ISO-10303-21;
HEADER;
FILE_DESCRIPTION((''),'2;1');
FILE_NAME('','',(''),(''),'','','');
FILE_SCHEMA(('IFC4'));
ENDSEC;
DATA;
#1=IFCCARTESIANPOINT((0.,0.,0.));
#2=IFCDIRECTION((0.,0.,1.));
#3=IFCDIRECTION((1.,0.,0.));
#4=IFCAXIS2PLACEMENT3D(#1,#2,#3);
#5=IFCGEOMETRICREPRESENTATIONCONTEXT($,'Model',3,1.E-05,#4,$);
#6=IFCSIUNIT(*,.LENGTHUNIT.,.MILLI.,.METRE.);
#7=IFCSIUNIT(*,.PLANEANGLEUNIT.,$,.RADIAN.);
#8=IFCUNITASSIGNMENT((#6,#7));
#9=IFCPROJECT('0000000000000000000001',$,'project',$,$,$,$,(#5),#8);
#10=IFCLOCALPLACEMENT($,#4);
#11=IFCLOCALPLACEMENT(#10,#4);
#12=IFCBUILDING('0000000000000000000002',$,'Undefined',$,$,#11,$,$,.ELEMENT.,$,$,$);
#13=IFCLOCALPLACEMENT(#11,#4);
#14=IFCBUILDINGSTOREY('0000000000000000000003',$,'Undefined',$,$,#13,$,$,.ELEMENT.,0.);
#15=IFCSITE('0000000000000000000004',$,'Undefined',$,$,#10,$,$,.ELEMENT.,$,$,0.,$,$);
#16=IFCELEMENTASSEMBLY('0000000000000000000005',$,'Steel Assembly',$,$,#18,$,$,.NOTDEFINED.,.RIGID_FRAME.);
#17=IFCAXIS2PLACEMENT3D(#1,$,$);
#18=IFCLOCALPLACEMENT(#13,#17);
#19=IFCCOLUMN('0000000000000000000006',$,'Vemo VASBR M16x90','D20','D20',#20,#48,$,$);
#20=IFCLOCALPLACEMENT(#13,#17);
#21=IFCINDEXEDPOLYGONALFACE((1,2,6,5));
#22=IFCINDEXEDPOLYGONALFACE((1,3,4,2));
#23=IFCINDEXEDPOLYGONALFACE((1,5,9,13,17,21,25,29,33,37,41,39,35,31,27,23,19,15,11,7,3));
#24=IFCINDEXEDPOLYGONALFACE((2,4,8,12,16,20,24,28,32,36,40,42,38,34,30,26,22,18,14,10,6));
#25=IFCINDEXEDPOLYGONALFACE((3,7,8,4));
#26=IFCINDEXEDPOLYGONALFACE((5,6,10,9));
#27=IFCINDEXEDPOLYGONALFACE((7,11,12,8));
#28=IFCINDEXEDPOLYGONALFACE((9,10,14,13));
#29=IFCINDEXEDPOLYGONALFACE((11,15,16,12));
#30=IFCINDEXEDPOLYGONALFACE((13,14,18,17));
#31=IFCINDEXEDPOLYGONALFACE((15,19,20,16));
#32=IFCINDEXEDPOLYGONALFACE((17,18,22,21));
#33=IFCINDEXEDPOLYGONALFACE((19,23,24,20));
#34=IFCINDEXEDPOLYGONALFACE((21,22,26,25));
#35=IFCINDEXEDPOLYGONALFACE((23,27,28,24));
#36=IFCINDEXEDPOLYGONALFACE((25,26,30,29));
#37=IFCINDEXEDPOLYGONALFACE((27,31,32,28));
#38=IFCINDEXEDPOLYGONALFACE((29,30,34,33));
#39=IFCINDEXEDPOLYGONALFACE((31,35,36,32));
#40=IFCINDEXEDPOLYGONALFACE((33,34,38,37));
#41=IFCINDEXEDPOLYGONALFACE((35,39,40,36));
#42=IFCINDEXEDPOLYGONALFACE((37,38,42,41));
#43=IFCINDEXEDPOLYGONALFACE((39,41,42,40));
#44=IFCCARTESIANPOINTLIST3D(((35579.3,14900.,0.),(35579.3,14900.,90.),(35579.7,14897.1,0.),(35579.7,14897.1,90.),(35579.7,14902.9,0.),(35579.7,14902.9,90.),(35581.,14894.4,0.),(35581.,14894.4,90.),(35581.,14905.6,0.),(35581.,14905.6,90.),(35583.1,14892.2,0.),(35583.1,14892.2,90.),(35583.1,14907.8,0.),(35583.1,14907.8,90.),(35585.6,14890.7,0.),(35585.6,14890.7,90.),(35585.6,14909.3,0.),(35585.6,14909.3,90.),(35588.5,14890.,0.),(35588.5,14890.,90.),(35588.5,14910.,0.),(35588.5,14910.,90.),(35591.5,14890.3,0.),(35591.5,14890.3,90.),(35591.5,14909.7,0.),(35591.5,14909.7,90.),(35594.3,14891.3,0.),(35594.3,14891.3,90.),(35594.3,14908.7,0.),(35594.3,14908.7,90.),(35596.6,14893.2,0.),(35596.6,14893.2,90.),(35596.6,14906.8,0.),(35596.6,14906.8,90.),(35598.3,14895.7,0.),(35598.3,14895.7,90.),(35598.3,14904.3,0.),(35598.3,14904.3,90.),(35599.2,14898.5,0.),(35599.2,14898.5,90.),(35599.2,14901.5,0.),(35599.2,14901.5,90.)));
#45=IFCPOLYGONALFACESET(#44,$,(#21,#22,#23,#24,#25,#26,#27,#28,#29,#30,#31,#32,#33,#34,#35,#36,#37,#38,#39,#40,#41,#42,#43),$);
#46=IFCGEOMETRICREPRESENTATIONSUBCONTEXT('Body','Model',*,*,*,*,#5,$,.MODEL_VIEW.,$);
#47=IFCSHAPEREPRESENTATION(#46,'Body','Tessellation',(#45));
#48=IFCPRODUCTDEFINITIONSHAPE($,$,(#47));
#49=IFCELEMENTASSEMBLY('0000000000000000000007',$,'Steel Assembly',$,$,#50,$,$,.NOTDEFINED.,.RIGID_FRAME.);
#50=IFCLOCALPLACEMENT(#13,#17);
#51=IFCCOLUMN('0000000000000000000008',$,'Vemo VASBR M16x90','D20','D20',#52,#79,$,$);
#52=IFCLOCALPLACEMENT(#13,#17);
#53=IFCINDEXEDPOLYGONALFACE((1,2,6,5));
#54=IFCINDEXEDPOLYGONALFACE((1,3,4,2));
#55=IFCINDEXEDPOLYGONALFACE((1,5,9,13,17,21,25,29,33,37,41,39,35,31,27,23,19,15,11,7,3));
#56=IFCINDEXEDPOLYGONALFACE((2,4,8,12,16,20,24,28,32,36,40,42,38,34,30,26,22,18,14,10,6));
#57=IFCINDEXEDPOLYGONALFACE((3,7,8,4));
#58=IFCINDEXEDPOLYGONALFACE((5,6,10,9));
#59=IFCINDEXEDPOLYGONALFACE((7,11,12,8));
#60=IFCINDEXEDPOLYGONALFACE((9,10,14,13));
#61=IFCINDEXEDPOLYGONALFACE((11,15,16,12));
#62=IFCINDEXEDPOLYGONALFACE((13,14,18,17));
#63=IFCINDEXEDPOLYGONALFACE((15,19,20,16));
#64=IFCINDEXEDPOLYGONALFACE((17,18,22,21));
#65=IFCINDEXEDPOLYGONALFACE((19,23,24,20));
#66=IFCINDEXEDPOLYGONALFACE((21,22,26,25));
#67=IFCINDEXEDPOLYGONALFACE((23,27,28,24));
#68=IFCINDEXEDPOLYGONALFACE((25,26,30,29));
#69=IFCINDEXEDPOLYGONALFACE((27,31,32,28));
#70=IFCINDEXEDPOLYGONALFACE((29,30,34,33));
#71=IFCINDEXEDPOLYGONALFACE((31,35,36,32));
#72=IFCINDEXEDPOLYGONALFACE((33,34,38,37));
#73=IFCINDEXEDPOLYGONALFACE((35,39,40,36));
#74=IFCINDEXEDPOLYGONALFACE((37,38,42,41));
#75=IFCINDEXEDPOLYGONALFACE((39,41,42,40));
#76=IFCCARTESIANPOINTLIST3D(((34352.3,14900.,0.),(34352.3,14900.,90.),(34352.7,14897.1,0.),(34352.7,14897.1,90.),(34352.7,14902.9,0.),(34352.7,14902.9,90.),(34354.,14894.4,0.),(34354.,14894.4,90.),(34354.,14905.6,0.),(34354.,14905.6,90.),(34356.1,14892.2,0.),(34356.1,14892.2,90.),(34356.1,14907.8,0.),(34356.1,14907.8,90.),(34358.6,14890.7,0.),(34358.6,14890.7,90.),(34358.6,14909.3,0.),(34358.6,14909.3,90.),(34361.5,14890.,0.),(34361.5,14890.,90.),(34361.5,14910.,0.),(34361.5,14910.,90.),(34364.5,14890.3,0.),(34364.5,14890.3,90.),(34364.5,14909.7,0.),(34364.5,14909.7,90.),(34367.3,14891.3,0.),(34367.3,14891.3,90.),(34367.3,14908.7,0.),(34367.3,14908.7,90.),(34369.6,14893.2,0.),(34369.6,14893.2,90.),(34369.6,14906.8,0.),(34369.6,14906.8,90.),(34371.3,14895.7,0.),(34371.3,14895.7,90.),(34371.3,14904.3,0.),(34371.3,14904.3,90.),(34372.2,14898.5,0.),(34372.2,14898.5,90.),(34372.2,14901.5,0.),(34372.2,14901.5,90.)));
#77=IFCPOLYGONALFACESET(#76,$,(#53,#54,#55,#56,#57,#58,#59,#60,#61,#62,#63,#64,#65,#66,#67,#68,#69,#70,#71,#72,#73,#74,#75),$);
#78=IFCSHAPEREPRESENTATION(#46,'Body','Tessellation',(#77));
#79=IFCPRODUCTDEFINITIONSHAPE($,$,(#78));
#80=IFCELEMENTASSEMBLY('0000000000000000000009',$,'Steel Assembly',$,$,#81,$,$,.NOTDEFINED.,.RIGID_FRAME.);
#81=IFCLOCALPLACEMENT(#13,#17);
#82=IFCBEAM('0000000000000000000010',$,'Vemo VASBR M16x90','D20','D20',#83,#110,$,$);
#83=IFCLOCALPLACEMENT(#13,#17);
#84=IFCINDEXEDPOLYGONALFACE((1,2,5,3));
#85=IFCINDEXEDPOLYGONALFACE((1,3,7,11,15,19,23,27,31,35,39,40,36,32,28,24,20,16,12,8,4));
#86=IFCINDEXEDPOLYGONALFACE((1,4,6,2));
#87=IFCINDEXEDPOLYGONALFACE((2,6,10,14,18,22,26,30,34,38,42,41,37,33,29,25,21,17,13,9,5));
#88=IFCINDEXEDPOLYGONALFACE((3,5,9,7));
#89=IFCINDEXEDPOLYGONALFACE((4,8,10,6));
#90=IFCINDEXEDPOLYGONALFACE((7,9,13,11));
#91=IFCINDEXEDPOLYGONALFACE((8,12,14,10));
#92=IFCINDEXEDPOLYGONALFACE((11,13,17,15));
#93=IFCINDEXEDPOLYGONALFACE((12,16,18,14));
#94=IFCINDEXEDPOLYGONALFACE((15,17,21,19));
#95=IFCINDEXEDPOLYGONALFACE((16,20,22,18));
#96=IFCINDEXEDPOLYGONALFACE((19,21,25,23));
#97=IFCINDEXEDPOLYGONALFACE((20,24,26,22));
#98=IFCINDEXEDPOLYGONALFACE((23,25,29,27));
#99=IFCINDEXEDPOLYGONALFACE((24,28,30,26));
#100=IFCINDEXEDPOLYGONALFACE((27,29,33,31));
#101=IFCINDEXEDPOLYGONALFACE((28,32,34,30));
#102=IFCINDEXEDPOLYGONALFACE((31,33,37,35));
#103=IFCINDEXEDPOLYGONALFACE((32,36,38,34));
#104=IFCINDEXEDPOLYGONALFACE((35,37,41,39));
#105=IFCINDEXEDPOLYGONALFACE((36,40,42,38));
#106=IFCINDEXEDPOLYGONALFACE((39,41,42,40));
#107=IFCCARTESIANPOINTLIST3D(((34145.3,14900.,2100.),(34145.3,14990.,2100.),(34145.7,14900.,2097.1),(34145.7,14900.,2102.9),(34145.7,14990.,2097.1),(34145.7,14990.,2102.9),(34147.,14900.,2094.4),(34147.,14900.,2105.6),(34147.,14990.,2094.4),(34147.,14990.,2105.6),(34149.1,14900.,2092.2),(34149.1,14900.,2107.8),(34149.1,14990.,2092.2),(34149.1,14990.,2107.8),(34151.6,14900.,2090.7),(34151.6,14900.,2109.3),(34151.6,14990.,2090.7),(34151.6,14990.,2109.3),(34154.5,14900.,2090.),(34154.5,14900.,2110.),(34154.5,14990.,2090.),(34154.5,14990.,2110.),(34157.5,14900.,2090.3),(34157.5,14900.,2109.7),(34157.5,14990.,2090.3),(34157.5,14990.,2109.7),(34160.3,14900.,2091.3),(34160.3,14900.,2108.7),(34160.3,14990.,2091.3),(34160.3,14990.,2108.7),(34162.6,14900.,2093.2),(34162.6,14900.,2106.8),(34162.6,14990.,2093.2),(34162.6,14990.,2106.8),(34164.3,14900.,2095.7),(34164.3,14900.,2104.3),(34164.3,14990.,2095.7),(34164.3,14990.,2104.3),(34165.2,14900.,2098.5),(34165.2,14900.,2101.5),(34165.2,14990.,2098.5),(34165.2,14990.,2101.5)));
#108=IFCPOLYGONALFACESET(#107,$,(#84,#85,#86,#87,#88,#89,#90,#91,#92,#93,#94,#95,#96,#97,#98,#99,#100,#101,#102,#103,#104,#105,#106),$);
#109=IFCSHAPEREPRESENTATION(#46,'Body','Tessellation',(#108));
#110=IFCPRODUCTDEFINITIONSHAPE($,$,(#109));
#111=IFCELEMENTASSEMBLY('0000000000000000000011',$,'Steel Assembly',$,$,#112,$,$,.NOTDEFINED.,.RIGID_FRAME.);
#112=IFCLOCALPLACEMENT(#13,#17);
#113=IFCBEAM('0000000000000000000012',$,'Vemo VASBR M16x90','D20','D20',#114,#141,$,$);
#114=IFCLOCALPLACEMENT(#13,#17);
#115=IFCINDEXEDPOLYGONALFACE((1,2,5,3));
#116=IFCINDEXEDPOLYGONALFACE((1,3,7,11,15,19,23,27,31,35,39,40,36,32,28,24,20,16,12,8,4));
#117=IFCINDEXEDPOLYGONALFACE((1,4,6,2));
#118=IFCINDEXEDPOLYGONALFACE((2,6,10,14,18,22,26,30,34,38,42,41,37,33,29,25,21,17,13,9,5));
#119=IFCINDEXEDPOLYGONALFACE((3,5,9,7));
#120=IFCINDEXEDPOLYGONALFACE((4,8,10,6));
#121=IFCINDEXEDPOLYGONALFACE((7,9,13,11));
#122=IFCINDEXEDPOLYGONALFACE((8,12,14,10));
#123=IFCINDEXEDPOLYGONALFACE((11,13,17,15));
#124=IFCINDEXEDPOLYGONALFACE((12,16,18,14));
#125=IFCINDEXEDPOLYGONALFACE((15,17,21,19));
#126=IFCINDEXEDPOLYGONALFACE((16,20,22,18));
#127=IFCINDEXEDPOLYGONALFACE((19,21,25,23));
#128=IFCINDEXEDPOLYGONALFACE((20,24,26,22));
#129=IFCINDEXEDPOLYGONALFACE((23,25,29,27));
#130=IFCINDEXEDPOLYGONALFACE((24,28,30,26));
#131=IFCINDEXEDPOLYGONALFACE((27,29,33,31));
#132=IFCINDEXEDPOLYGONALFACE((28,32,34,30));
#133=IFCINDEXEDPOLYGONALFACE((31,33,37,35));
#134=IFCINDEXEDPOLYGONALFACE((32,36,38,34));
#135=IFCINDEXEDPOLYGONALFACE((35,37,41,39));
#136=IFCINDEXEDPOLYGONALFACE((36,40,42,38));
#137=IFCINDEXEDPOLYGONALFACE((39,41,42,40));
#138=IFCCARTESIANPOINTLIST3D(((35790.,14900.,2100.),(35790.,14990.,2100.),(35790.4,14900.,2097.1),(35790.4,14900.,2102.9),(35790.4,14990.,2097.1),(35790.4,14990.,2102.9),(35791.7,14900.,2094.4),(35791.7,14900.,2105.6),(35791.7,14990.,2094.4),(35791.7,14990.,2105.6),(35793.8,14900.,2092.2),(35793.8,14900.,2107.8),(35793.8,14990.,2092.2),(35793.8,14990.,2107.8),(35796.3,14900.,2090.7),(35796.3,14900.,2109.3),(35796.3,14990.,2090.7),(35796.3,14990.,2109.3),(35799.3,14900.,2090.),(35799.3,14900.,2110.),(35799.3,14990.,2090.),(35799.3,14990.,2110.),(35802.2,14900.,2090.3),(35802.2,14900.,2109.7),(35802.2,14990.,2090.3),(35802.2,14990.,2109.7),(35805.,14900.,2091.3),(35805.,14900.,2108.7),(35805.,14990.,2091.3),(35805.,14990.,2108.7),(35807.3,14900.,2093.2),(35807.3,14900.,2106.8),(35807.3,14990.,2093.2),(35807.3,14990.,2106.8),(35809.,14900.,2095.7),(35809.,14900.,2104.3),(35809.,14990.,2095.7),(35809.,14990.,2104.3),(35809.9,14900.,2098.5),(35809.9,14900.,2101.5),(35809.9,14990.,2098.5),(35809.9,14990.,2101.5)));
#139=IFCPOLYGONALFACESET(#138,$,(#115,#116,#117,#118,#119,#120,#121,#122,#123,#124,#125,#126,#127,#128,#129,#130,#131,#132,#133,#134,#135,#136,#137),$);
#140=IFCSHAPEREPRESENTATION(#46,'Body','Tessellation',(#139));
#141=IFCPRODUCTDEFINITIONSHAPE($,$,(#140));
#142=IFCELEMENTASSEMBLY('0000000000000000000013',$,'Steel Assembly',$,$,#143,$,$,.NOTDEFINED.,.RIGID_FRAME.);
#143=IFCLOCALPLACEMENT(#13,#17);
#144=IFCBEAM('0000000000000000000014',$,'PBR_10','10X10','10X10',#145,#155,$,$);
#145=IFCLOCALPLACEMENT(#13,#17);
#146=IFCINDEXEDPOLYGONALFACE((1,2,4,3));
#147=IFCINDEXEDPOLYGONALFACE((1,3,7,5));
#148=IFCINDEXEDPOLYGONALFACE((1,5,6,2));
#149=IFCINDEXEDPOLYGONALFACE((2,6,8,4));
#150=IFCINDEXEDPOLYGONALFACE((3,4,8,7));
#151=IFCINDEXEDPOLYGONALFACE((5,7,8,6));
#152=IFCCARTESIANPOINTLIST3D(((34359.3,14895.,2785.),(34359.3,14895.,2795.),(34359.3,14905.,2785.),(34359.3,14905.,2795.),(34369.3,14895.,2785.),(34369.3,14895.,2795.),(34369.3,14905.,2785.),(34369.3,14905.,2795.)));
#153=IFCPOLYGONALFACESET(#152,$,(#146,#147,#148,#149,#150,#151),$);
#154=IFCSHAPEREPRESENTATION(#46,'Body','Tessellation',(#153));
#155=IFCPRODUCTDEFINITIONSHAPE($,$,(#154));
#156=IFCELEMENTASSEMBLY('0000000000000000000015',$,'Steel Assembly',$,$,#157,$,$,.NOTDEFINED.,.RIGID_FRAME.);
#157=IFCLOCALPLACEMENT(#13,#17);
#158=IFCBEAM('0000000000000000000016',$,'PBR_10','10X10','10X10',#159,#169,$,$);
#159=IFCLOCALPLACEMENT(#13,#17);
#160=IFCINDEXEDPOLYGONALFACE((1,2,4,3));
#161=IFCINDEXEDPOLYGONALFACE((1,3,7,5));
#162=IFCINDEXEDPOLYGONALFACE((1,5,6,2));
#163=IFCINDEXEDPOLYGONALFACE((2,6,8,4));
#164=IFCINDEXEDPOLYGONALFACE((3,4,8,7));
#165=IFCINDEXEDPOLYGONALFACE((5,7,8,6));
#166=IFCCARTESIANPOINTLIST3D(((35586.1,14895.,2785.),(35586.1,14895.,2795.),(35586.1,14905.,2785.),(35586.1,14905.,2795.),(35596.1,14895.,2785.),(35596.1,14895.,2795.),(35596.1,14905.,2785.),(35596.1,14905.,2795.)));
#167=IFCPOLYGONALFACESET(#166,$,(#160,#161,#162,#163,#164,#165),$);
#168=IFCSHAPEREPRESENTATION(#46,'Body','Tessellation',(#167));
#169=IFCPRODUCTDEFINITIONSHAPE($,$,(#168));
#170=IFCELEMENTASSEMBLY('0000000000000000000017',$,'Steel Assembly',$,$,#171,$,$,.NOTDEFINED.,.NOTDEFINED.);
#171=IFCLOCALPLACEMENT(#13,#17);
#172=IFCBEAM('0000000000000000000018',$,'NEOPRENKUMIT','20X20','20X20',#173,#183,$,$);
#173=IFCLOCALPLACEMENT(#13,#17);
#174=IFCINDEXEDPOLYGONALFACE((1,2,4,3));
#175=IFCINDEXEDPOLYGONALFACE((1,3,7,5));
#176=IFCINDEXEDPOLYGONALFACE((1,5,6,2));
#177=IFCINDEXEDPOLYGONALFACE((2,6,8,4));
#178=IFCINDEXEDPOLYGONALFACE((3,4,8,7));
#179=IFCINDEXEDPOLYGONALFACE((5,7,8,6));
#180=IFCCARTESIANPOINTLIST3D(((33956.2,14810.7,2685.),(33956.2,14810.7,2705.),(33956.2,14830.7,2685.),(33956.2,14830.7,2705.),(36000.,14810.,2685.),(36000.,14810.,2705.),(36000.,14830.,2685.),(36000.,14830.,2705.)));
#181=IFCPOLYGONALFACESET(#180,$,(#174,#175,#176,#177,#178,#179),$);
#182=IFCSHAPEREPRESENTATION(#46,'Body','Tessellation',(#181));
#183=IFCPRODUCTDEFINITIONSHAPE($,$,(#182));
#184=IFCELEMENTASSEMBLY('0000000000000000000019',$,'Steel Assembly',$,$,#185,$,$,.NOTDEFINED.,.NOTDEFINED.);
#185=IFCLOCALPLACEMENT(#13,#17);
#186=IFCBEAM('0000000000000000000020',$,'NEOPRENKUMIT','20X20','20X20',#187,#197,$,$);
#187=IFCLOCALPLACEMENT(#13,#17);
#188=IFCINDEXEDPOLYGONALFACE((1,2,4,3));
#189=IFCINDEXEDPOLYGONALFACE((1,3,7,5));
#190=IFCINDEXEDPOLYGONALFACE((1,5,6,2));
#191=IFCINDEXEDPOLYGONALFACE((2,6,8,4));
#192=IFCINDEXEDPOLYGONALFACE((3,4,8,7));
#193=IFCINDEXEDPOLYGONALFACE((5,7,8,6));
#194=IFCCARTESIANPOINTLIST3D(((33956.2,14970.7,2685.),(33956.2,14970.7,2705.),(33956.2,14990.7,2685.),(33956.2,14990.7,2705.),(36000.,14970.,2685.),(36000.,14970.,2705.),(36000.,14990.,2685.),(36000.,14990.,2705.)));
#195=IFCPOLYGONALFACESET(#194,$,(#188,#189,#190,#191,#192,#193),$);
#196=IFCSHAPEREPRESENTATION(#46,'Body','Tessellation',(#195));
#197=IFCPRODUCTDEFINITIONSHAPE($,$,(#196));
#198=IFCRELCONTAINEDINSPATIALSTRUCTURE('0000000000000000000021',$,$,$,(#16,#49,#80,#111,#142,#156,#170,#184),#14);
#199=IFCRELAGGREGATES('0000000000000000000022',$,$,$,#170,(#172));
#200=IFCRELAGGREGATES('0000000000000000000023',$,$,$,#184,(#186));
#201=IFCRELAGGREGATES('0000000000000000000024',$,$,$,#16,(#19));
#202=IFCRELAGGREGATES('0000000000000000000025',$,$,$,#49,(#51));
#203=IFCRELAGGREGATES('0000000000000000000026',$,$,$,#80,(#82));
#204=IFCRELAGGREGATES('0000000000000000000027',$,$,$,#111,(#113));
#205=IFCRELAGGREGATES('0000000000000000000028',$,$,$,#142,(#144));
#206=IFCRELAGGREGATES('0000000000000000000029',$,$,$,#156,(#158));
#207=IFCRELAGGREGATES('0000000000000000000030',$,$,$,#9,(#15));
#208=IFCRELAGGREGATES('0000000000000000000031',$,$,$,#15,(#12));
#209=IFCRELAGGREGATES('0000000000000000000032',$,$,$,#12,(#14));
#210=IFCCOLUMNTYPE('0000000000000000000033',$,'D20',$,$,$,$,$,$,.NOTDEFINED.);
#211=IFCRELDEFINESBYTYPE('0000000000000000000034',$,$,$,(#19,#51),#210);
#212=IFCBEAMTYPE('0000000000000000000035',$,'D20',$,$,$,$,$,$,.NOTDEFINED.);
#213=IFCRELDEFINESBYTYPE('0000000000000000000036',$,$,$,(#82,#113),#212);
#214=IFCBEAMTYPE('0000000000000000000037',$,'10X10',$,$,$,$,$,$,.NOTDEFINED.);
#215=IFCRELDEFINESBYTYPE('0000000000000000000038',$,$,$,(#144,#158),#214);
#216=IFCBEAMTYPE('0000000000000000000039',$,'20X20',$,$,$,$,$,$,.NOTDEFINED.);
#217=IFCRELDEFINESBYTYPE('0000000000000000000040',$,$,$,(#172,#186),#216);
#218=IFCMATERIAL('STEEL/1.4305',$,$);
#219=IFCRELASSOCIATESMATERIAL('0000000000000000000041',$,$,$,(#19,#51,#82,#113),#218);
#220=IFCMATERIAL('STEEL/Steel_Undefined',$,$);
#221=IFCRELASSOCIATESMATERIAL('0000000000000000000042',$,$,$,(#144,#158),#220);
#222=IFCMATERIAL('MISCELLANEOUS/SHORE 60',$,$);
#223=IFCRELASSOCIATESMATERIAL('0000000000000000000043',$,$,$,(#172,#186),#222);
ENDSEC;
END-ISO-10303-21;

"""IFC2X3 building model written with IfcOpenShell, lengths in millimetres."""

from ifc_helpers import new_model, si_unit, frame, origin_with_axes, origin_2d_with_axis, place, context, subcontext, project, spatial, rectangle, circle, extrude, material, type_object, element, aggregate, save


model = new_model("IFC2X3")

# Units and contexts
model_context = context("Model", 3, precision=1e-05, world=origin_with_axes())
body_context = subcontext(model_context, "Body", "Model", "MODEL_VIEW")
ifc_project = project(units=[si_unit("LENGTHUNIT", "METRE", prefix="MILLI"), si_unit("PLANEANGLEUNIT", "RADIAN")], contexts=[model_context])

# Site, building, storey
site_placement = place(None, origin_with_axes())
site = spatial("IfcSite", under=ifc_project, at=site_placement, Name="Undefined", CompositionType="ELEMENT", RefElevation=0.0)
building_placement = place(site_placement, origin_with_axes())
building = spatial("IfcBuilding", under=site, at=building_placement, Name="Undefined", CompositionType="ELEMENT")
storey_placement = place(building_placement, origin_with_axes())
storey = spatial("IfcBuildingStorey", under=building, at=storey_placement, Name="Undefined", CompositionType="ELEMENT", Elevation=0.0)

# Element assemblies, columns
assembly_1_placement = place(storey_placement, origin_with_axes())
assembly_1 = element("IfcElementAssembly", 1, at=assembly_1_placement, inside=storey, Name="Steel Assembly", AssemblyPlace="NOTDEFINED", PredefinedType="RIGID_FRAME")
ifc_material_1 = material(Name="STEEL/1.4305")
column_type = type_object("IfcColumnType", Name="D20", PredefinedType="NOTDEFINED")
column_1_placement = place(assembly_1_placement, frame((35589.3, 14900.0, 0.0), z_axis=(0.0, 0.0, 1.0), x_axis=(0.0, 1.0, 0.0)))
column_1 = element("IfcColumn", 2, at=column_1_placement, type_object=column_type, material=ifc_material_1, Name="Vemo VASBR M16x90", Description="D20", ObjectType="D20", context=body_context, shape_type="SweptSolid", body=[
    extrude(circle(Radius=10.0, at=origin_2d_with_axis()), frame((0.0, 0.0, 90.0), z_axis=(0.0, 0.0, -1.0), x_axis=(0.0, 1.0, 0.0)), (0.0, 0.0, 1.0), 90.0),
])
assembly_2_placement = place(storey_placement, origin_with_axes())
assembly_2 = element("IfcElementAssembly", 3, at=assembly_2_placement, inside=storey, Name="Steel Assembly", AssemblyPlace="NOTDEFINED", PredefinedType="RIGID_FRAME")
column_2_placement = place(assembly_2_placement, frame((34362.3, 14900.0, 0.0), z_axis=(0.0, 0.0, 1.0), x_axis=(0.0, 1.0, 0.0)))
column_2 = element("IfcColumn", 4, at=column_2_placement, type_object=column_type, material=ifc_material_1, Name="Vemo VASBR M16x90", Description="D20", ObjectType="D20", context=body_context, shape_type="SweptSolid", body=[
    extrude(circle(Radius=10.0, at=origin_2d_with_axis()), frame((0.0, 0.0, 90.0), z_axis=(0.0, 0.0, -1.0), x_axis=(0.0, 1.0, 0.0)), (0.0, 0.0, 1.0), 90.0),
])

# Element assemblies, beams
assembly_3_placement = place(storey_placement, origin_with_axes())
assembly_3 = element("IfcElementAssembly", 5, at=assembly_3_placement, inside=storey, Name="Steel Assembly", AssemblyPlace="NOTDEFINED", PredefinedType="RIGID_FRAME")
beam_type_1 = type_object("IfcBeamType", Name="D20", PredefinedType="NOTDEFINED")
beam_1_placement = place(assembly_3_placement, frame((34155.3, 14990.0, 2100.0), z_axis=(0.0, 0.0, 1.0), x_axis=(0.0, -1.0, 0.0)))
beam_1 = element("IfcBeam", 6, at=beam_1_placement, type_object=beam_type_1, material=ifc_material_1, Name="Vemo VASBR M16x90", Description="D20", ObjectType="D20", context=body_context, shape_type="SweptSolid", body=[
    extrude(circle(Radius=10.0, at=origin_2d_with_axis()), frame((90.0, 0.0, 0.0), z_axis=(-1.0, 0.0, 0.0), x_axis=(0.0, -1.0, 0.0)), (0.0, 0.0, 1.0), 90.0),
])
assembly_4_placement = place(storey_placement, origin_with_axes())
assembly_4 = element("IfcElementAssembly", 7, at=assembly_4_placement, inside=storey, Name="Steel Assembly", AssemblyPlace="NOTDEFINED", PredefinedType="RIGID_FRAME")
beam_2_placement = place(assembly_4_placement, frame((35800.0, 14990.0, 2100.0), z_axis=(0.0, 0.0, 1.0), x_axis=(0.0, -1.0, 0.0)))
beam_2 = element("IfcBeam", 8, at=beam_2_placement, type_object=beam_type_1, material=ifc_material_1, Name="Vemo VASBR M16x90", Description="D20", ObjectType="D20", context=body_context, shape_type="SweptSolid", body=[
    extrude(circle(Radius=10.0, at=origin_2d_with_axis()), frame((90.0, 0.0, 0.0), z_axis=(-1.0, 0.0, 0.0), x_axis=(0.0, -1.0, 0.0)), (0.0, 0.0, 1.0), 90.0),
])
assembly_5_placement = place(storey_placement, origin_with_axes())
assembly_5 = element("IfcElementAssembly", 9, at=assembly_5_placement, inside=storey, Name="Steel Assembly", AssemblyPlace="NOTDEFINED", PredefinedType="RIGID_FRAME")
ifc_material_2 = material(Name="STEEL/Steel_Undefined")
beam_type_2 = type_object("IfcBeamType", Name="10X10", PredefinedType="NOTDEFINED")
beam_3_placement = place(assembly_5_placement, frame((34369.3, 14900.0, 2790.0), z_axis=(0.0, 0.0, 1.0), x_axis=(-1.0, 0.0, 0.0)))
beam_3 = element("IfcBeam", 10, at=beam_3_placement, type_object=beam_type_2, material=ifc_material_2, Name="PBR_10", Description="10X10", ObjectType="10X10", context=body_context, shape_type="SweptSolid", body=[
    extrude(rectangle(XDim=10.0, YDim=10.0, at=origin_2d_with_axis()), frame((10.0, 0.0, 0.0), z_axis=(-1.0, 0.0, 0.0), x_axis=(0.0, -1.0, 0.0)), (0.0, 0.0, 1.0), 10.0),
])
assembly_6_placement = place(storey_placement, origin_with_axes())
assembly_6 = element("IfcElementAssembly", 11, at=assembly_6_placement, inside=storey, Name="Steel Assembly", AssemblyPlace="NOTDEFINED", PredefinedType="RIGID_FRAME")
beam_4_placement = place(assembly_6_placement, frame((35586.1, 14900.0, 2790.0), z_axis=(0.0, 0.0, 1.0), x_axis=(1.0, 0.0, 0.0)))
beam_4 = element("IfcBeam", 12, at=beam_4_placement, type_object=beam_type_2, material=ifc_material_2, Name="PBR_10", Description="10X10", ObjectType="10X10", context=body_context, shape_type="SweptSolid", body=[
    extrude(rectangle(XDim=10.0, YDim=10.0, at=origin_2d_with_axis()), frame((10.0, 0.0, 0.0), z_axis=(-1.0, 0.0, 0.0), x_axis=(0.0, -1.0, 0.0)), (0.0, 0.0, 1.0), 10.0),
])
assembly_7_placement = place(storey_placement, origin_with_axes())
assembly_7 = element("IfcElementAssembly", 13, at=assembly_7_placement, inside=storey, Name="Steel Assembly", AssemblyPlace="NOTDEFINED", PredefinedType="NOTDEFINED")
ifc_material_3 = material(Name="MISCELLANEOUS/SHORE 60")
beam_type_3 = type_object("IfcBeamType", Name="20X20", PredefinedType="NOTDEFINED")
beam_5_placement = place(assembly_7_placement, frame((36000.0, 14820.0, 2695.0), z_axis=(0.0, 0.0, 1.0), x_axis=(-1.0, 0.000362, 0.0)))
beam_5 = element("IfcBeam", 14, at=beam_5_placement, type_object=beam_type_3, material=ifc_material_3, Name="NEOPRENKUMIT", Description="20X20", ObjectType="20X20", context=body_context, shape_type="SweptSolid", body=[
    extrude(rectangle(XDim=20.0, YDim=20.0, at=origin_2d_with_axis()), frame((2043.8, 0.0, 0.0), z_axis=(-1.0, 0.0, 0.0), x_axis=(0.0, -1.0, 0.0)), (0.0, 0.0, 1.0), 2043.8),
])
aggregate(assembly_7, [beam_5])
assembly_8_placement = place(storey_placement, origin_with_axes())
assembly_8 = element("IfcElementAssembly", 15, at=assembly_8_placement, inside=storey, Name="Steel Assembly", AssemblyPlace="NOTDEFINED", PredefinedType="NOTDEFINED")
beam_6_placement = place(assembly_8_placement, frame((36000.0, 14980.0, 2695.0), z_axis=(0.0, 0.0, 1.0), x_axis=(-1.0, 0.000362, 0.0)))
beam_6 = element("IfcBeam", 16, at=beam_6_placement, type_object=beam_type_3, material=ifc_material_3, Name="NEOPRENKUMIT", Description="20X20", ObjectType="20X20", context=body_context, shape_type="SweptSolid", body=[
    extrude(rectangle(XDim=20.0, YDim=20.0, at=origin_2d_with_axis()), frame((2043.8, 0.0, 0.0), z_axis=(-1.0, 0.0, 0.0), x_axis=(0.0, -1.0, 0.0)), (0.0, 0.0, 1.0), 2043.8),
])
aggregate(assembly_8, [beam_6])

aggregate(assembly_1, [column_1])
aggregate(assembly_2, [column_2])
aggregate(assembly_3, [beam_1])
aggregate(assembly_4, [beam_2])

aggregate(assembly_5, [beam_3])
aggregate(assembly_6, [beam_4])

save(model, "model.ifc")
